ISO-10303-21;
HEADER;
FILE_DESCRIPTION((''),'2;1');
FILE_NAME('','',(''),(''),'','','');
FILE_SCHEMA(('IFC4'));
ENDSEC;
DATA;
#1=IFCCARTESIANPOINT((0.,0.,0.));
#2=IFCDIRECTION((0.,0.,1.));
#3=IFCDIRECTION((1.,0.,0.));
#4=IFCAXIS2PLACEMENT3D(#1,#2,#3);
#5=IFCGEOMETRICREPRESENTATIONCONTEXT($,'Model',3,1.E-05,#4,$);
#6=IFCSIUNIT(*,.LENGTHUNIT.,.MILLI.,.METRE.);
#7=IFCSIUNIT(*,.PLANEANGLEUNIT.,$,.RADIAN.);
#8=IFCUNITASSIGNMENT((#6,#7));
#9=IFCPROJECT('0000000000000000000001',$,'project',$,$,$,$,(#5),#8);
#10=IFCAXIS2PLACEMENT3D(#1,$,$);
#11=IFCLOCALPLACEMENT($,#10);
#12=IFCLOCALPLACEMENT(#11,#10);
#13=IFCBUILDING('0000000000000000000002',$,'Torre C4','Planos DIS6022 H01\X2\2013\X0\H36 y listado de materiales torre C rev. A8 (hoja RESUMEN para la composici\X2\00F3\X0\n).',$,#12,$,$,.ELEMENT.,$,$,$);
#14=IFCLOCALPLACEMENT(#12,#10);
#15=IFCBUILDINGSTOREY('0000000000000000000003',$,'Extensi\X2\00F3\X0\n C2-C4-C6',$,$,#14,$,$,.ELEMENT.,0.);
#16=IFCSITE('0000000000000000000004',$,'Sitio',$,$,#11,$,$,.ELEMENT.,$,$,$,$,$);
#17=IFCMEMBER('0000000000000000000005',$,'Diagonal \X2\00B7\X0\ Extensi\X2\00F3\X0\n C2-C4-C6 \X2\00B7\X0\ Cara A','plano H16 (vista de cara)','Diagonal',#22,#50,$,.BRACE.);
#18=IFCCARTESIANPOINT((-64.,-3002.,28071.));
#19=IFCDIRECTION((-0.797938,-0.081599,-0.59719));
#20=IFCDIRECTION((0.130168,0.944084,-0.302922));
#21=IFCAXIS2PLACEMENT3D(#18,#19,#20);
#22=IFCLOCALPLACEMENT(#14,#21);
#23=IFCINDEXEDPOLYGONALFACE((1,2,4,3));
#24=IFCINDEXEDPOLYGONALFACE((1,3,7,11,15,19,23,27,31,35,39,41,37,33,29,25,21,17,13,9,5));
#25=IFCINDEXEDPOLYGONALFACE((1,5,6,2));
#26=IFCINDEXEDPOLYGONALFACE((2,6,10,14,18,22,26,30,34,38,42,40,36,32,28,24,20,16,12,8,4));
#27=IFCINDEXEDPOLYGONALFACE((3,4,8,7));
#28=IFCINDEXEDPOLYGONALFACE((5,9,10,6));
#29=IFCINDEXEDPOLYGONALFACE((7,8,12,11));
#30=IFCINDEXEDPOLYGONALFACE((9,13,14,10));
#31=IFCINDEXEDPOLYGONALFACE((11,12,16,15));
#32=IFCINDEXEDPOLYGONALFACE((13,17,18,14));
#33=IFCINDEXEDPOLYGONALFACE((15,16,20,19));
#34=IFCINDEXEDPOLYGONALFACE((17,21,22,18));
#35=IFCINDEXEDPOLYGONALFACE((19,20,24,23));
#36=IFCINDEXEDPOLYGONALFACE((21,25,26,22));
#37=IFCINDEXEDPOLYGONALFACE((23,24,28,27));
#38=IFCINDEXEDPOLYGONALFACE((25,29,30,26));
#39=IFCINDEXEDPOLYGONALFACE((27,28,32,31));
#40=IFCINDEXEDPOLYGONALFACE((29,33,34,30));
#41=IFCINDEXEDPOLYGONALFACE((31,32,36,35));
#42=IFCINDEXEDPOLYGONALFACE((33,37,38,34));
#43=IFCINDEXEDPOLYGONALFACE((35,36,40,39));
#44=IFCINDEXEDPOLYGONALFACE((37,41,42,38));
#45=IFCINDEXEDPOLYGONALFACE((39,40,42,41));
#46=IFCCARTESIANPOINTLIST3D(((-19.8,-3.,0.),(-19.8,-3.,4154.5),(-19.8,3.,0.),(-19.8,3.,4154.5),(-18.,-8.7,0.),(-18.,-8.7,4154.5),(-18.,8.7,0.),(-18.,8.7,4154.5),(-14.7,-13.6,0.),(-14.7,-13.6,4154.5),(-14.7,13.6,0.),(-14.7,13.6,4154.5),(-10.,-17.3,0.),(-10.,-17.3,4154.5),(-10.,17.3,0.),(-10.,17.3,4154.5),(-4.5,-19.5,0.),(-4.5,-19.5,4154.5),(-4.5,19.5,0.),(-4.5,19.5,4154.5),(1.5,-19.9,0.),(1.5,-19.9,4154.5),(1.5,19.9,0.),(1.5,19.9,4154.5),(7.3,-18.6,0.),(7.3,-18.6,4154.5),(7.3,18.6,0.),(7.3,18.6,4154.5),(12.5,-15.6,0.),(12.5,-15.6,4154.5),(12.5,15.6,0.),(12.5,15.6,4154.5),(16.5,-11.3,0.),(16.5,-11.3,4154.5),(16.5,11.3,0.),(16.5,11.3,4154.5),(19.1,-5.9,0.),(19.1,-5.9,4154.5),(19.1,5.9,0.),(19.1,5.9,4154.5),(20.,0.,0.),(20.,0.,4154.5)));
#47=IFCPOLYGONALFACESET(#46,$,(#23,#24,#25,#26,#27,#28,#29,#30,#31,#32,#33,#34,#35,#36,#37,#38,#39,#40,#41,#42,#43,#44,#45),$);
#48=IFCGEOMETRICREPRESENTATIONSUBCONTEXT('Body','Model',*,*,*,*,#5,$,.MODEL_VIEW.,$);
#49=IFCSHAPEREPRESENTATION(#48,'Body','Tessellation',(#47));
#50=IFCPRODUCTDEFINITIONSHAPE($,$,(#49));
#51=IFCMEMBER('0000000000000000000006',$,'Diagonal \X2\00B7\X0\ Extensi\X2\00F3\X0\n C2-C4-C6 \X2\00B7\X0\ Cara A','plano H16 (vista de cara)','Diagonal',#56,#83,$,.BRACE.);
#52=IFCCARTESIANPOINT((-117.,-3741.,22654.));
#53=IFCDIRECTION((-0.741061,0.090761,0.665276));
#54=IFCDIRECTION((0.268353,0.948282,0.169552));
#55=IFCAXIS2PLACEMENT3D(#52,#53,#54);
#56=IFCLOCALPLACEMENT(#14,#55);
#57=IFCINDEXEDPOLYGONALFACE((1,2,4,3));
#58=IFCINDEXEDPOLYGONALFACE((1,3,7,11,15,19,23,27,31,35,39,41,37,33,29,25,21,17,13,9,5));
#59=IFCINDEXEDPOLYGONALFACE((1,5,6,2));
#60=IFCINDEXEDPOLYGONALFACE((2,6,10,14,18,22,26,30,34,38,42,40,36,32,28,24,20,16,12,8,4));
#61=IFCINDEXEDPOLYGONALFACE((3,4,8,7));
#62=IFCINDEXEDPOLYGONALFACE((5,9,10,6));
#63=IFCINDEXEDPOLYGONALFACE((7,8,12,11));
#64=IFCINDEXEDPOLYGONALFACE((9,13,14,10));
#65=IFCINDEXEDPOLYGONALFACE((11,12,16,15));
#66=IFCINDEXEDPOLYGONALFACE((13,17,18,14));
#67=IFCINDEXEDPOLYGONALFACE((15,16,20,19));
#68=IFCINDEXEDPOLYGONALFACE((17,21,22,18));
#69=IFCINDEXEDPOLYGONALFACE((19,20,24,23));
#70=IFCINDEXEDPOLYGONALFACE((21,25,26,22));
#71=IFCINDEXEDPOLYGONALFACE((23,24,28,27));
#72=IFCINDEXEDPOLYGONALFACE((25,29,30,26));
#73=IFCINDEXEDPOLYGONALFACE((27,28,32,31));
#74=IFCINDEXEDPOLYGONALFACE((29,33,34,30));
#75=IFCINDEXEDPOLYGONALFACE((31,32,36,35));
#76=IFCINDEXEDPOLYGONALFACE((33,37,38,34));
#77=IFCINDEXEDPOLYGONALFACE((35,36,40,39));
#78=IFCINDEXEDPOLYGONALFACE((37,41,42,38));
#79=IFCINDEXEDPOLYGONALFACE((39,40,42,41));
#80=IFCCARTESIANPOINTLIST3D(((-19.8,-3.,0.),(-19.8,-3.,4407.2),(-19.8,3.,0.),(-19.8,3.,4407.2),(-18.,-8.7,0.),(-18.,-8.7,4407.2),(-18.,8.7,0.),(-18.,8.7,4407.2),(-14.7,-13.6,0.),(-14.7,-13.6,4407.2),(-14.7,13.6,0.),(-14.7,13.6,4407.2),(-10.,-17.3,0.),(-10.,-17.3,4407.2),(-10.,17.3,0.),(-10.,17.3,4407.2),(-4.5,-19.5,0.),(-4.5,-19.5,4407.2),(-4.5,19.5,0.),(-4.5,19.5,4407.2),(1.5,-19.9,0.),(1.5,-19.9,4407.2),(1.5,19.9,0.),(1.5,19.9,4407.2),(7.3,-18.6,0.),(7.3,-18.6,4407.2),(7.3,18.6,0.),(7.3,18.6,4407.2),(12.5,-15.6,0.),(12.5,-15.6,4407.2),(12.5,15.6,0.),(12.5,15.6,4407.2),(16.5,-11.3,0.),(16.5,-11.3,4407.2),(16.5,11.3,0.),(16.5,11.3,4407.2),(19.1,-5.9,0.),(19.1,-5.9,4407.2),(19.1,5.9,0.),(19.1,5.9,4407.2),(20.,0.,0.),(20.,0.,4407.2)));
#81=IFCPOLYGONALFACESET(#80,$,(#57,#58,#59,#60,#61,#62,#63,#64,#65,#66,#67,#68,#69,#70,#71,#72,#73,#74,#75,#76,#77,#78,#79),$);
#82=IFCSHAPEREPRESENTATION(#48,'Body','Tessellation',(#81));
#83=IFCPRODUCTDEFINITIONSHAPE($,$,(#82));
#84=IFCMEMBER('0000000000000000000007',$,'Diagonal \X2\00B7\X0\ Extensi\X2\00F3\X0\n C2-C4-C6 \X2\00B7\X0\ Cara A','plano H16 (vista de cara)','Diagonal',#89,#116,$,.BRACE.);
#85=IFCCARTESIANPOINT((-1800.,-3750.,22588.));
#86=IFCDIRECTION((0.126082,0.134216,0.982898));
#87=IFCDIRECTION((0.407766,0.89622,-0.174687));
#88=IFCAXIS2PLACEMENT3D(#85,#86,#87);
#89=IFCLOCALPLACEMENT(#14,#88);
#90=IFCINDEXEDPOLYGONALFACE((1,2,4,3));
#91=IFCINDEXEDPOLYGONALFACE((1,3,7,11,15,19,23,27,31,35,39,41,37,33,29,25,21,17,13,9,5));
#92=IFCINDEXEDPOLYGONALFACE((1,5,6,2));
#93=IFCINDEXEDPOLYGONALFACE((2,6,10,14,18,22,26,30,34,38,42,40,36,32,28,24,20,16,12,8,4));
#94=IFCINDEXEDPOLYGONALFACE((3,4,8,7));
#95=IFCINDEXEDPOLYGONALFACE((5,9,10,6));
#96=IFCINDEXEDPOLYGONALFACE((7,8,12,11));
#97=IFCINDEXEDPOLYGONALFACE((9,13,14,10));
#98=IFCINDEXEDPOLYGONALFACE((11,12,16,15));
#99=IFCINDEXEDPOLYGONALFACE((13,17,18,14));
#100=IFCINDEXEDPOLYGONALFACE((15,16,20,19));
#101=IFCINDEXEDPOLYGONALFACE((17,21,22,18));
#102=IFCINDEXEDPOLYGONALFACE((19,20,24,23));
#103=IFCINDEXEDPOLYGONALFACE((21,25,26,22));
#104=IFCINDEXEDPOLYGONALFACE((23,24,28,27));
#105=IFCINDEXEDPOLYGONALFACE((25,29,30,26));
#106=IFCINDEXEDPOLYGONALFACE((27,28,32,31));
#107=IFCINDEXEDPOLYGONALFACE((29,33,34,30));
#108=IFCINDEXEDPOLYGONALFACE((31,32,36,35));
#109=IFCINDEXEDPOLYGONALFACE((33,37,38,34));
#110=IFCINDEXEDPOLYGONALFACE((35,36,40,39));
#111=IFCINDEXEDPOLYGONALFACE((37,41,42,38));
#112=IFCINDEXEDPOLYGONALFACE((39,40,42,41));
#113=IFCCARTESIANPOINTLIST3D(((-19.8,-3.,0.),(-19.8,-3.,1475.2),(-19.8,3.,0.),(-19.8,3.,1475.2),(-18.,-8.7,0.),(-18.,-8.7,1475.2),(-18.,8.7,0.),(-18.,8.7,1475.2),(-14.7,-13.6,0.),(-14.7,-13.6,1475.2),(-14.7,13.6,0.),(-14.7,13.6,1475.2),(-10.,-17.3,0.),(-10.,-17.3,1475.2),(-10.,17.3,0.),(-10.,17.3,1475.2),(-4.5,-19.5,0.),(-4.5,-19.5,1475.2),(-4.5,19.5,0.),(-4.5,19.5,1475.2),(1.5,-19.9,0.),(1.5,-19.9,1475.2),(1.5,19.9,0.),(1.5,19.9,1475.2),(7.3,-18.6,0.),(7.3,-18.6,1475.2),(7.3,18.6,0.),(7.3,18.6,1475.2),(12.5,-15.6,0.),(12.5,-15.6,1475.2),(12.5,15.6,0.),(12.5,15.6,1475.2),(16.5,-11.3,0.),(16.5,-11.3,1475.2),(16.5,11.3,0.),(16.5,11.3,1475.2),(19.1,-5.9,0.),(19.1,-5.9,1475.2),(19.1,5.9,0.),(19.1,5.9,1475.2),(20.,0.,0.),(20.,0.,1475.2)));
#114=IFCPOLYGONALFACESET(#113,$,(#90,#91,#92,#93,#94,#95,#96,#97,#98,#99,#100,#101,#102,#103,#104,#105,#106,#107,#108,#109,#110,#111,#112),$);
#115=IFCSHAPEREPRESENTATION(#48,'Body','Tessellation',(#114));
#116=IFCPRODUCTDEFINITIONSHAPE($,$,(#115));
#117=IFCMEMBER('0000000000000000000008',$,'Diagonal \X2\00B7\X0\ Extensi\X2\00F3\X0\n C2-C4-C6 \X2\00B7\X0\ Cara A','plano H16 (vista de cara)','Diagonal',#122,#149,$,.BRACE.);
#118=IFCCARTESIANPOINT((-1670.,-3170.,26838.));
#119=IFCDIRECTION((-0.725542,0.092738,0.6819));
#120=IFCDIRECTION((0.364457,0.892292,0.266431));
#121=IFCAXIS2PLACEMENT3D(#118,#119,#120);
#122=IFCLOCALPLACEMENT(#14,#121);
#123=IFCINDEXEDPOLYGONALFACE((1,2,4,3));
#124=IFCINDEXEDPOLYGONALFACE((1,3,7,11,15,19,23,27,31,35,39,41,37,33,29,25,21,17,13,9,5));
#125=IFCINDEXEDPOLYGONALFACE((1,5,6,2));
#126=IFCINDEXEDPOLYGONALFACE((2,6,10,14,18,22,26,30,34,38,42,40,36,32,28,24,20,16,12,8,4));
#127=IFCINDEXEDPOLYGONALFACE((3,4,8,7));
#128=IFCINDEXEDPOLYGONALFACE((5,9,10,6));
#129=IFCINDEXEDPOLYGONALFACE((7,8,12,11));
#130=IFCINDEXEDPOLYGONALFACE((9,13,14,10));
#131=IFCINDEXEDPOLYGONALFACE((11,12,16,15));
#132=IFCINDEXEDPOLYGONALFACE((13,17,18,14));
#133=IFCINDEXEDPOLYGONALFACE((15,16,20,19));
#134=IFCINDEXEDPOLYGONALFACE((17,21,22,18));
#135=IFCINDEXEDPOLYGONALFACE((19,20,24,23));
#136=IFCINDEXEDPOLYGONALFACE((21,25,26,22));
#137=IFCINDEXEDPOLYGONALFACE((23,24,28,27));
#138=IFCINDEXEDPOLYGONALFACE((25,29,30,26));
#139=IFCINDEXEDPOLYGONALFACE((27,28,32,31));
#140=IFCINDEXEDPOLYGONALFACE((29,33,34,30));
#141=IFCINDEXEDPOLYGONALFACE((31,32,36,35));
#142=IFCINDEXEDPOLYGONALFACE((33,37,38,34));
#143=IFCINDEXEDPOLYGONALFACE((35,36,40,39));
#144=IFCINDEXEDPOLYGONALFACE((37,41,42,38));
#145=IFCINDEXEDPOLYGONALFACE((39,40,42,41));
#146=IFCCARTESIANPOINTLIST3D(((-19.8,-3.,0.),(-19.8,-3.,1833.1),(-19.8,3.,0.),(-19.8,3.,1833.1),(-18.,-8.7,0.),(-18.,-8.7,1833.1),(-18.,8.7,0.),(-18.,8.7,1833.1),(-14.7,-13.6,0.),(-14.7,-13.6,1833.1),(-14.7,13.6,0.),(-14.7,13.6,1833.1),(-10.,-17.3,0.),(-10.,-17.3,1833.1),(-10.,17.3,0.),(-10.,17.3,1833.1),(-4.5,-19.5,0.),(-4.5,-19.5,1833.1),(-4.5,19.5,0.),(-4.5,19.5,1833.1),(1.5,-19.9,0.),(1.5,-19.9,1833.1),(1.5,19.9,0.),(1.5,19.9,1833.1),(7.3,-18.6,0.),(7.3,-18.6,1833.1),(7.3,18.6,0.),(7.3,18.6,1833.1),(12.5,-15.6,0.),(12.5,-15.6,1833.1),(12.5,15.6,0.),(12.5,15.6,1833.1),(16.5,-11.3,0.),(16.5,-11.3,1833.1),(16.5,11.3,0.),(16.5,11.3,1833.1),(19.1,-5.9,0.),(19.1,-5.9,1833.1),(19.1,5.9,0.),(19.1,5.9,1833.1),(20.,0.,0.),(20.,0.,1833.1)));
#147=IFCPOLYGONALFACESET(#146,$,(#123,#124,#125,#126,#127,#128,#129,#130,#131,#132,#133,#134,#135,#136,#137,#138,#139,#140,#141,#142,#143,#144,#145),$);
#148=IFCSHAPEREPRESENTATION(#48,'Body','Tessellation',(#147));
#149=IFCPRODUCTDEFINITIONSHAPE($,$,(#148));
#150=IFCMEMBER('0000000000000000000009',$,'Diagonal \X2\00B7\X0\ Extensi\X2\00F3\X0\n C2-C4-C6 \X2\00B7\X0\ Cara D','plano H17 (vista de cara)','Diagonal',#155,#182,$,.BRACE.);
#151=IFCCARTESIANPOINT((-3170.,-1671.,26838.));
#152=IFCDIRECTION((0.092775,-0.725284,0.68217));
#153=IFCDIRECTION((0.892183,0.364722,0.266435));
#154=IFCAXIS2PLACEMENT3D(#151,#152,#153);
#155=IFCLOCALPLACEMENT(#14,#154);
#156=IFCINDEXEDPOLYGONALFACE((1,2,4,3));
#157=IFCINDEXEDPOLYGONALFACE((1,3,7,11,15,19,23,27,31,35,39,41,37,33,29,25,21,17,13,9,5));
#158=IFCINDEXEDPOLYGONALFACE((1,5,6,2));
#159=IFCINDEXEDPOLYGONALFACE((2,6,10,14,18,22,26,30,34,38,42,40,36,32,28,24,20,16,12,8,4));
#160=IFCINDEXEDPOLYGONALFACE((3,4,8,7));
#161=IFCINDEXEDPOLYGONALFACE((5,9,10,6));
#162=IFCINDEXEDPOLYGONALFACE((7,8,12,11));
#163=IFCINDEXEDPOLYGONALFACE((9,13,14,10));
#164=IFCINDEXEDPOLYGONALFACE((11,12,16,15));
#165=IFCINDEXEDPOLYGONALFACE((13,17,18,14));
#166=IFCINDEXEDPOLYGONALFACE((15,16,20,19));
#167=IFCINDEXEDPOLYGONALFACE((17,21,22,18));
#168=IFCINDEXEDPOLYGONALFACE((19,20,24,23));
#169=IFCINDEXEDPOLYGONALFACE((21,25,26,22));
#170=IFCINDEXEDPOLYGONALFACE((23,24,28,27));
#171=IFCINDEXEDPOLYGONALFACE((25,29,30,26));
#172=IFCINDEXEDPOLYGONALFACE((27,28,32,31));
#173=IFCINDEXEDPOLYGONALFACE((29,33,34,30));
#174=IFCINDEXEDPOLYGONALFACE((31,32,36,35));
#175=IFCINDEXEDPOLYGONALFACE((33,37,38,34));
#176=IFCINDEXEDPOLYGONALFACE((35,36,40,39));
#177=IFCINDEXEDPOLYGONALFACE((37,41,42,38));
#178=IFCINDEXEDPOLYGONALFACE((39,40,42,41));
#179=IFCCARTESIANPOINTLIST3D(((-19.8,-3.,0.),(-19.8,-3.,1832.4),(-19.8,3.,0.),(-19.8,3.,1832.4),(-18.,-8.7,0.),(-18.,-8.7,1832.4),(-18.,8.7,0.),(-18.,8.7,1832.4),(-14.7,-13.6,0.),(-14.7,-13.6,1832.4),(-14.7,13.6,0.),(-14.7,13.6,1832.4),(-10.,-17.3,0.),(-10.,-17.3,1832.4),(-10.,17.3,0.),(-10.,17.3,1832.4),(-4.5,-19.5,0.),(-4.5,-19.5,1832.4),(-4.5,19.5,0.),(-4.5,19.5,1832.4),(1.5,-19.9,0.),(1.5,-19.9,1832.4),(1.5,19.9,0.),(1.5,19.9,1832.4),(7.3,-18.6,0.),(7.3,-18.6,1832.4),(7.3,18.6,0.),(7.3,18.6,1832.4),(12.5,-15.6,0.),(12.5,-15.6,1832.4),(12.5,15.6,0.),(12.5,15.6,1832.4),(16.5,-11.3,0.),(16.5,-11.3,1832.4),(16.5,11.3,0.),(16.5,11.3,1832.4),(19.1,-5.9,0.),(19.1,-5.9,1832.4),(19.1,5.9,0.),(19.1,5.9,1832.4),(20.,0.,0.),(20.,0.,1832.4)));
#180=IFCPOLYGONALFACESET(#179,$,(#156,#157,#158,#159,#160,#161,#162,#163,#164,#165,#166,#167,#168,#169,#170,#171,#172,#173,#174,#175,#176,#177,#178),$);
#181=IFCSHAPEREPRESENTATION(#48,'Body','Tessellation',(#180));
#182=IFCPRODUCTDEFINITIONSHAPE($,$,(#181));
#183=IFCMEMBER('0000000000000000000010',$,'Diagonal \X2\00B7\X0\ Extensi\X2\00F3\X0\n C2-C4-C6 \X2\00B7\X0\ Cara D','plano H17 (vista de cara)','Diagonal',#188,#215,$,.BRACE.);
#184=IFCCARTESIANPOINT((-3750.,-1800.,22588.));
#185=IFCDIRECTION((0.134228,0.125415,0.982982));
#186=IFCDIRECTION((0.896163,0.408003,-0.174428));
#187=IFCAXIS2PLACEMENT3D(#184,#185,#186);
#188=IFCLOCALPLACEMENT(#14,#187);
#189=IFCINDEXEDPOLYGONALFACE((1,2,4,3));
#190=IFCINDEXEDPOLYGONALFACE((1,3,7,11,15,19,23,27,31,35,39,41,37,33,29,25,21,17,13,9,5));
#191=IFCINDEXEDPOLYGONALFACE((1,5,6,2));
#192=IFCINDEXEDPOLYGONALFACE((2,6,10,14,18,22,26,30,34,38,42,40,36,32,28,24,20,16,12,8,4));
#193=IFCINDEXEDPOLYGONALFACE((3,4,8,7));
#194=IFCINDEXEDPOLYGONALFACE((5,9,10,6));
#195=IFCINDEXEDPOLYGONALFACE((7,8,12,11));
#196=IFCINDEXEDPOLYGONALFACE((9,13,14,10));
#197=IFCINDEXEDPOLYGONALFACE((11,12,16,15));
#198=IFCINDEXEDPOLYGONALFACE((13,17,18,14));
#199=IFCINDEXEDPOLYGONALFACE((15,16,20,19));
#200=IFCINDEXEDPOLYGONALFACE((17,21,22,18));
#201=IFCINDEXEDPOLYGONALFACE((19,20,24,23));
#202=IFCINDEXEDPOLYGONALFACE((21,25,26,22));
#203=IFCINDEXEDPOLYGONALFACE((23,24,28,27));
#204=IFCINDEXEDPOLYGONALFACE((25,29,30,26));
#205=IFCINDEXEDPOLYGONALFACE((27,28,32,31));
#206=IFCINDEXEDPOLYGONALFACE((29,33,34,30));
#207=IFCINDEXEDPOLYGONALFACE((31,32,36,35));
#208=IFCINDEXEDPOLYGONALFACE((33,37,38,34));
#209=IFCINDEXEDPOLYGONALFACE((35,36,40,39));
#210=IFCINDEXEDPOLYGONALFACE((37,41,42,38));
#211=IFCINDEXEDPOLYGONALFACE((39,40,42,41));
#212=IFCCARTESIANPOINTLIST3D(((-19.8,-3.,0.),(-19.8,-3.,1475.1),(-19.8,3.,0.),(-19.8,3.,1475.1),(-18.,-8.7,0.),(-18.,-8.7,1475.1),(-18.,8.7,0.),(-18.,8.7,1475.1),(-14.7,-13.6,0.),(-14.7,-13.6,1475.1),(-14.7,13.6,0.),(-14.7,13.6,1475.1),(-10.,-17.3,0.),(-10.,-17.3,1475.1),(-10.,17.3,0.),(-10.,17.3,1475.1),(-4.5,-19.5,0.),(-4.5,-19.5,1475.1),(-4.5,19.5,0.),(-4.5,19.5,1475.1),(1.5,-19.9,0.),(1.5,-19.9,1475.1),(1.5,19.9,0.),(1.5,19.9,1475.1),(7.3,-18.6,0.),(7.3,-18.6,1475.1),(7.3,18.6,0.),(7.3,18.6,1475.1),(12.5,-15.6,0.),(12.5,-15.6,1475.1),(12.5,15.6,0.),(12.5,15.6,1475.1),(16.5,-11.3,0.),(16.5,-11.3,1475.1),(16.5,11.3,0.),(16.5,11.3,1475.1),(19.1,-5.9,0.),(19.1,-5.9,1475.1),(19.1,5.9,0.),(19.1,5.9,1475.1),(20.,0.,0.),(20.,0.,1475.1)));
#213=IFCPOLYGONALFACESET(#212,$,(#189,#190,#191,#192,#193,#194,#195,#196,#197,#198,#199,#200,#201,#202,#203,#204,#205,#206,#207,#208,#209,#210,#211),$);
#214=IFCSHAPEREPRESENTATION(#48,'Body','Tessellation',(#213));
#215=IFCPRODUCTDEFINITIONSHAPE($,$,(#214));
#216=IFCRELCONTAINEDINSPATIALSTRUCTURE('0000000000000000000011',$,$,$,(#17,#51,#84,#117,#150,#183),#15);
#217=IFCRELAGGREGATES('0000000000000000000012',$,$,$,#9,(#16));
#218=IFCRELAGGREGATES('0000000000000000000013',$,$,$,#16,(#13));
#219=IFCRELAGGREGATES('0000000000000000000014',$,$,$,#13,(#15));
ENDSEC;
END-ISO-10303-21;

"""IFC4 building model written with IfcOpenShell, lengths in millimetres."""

from ifc_helpers import new_model, si_unit, frame, origin, origin_with_axes, place, context, subcontext, project, spatial, circle, extrude, element, save


model = new_model("IFC4")

# Units and contexts
model_context = context("Model", 3, precision=1e-05, world=origin_with_axes())
body_context = subcontext(model_context, "Body", "Model", "MODEL_VIEW")
ifc_project = project(units=[si_unit("LENGTHUNIT", "METRE", prefix="MILLI"), si_unit("PLANEANGLEUNIT", "RADIAN")], contexts=[model_context])

# Site, building, storey
site_placement = place(None, origin())
site = spatial("IfcSite", under=ifc_project, at=site_placement, Name="Sitio", CompositionType="ELEMENT")
building_placement = place(site_placement, origin())
building = spatial("IfcBuilding", under=site, at=building_placement, Name="Torre C4", Description="Planos DIS6022 H01–H36 y listado de materiales torre C rev. A8 (hoja RESUMEN para la composición).", CompositionType="ELEMENT")
storey_placement = place(building_placement, origin())
storey = spatial("IfcBuildingStorey", under=building, at=storey_placement, Name="Extensión C2-C4-C6", CompositionType="ELEMENT", Elevation=0.0)

# Members
member_1_placement = place(storey_placement, frame((-64.0, -3002.0, 28071.0), z_axis=(-0.797938, -0.081599, -0.59719), x_axis=(0.130168, 0.944084, -0.302922)))
element("IfcMember", 1, at=member_1_placement, inside=storey, Name="Diagonal · Extensión C2-C4-C6 · Cara A", Description="plano H16 (vista de cara)", ObjectType="Diagonal", PredefinedType="BRACE", context=body_context, shape_type="SweptSolid", body=[
    extrude(circle(Radius=20.0), None, (0.0, 0.0, 1.0), 4154.5),
])
member_2_placement = place(storey_placement, frame((-117.0, -3741.0, 22654.0), z_axis=(-0.741061, 0.090761, 0.665276), x_axis=(0.268353, 0.948282, 0.169552)))
element("IfcMember", 2, at=member_2_placement, inside=storey, Name="Diagonal · Extensión C2-C4-C6 · Cara A", Description="plano H16 (vista de cara)", ObjectType="Diagonal", PredefinedType="BRACE", context=body_context, shape_type="SweptSolid", body=[
    extrude(circle(Radius=20.0), None, (0.0, 0.0, 1.0), 4407.2),
])
member_3_placement = place(storey_placement, frame((-1800.0, -3750.0, 22588.0), z_axis=(0.126082, 0.134216, 0.982898), x_axis=(0.407766, 0.89622, -0.174687)))
element("IfcMember", 3, at=member_3_placement, inside=storey, Name="Diagonal · Extensión C2-C4-C6 · Cara A", Description="plano H16 (vista de cara)", ObjectType="Diagonal", PredefinedType="BRACE", context=body_context, shape_type="SweptSolid", body=[
    extrude(circle(Radius=20.0), None, (0.0, 0.0, 1.0), 1475.2),
])
member_4_placement = place(storey_placement, frame((-1670.0, -3170.0, 26838.0), z_axis=(-0.725542, 0.092738, 0.6819), x_axis=(0.364457, 0.892292, 0.266431)))
element("IfcMember", 4, at=member_4_placement, inside=storey, Name="Diagonal · Extensión C2-C4-C6 · Cara A", Description="plano H16 (vista de cara)", ObjectType="Diagonal", PredefinedType="BRACE", context=body_context, shape_type="SweptSolid", body=[
    extrude(circle(Radius=20.0), None, (0.0, 0.0, 1.0), 1833.1),
])
member_5_placement = place(storey_placement, frame((-3170.0, -1671.0, 26838.0), z_axis=(0.092775, -0.725284, 0.68217), x_axis=(0.892183, 0.364722, 0.266435)))
element("IfcMember", 5, at=member_5_placement, inside=storey, Name="Diagonal · Extensión C2-C4-C6 · Cara D", Description="plano H17 (vista de cara)", ObjectType="Diagonal", PredefinedType="BRACE", context=body_context, shape_type="SweptSolid", body=[
    extrude(circle(Radius=20.0), None, (0.0, 0.0, 1.0), 1832.4),
])
member_6_placement = place(storey_placement, frame((-3750.0, -1800.0, 22588.0), z_axis=(0.134228, 0.125415, 0.982982), x_axis=(0.896163, 0.408003, -0.174428)))
element("IfcMember", 6, at=member_6_placement, inside=storey, Name="Diagonal · Extensión C2-C4-C6 · Cara D", Description="plano H17 (vista de cara)", ObjectType="Diagonal", PredefinedType="BRACE", context=body_context, shape_type="SweptSolid", body=[
    extrude(circle(Radius=20.0), None, (0.0, 0.0, 1.0), 1475.1),
])

save(model, "model.ifc")
